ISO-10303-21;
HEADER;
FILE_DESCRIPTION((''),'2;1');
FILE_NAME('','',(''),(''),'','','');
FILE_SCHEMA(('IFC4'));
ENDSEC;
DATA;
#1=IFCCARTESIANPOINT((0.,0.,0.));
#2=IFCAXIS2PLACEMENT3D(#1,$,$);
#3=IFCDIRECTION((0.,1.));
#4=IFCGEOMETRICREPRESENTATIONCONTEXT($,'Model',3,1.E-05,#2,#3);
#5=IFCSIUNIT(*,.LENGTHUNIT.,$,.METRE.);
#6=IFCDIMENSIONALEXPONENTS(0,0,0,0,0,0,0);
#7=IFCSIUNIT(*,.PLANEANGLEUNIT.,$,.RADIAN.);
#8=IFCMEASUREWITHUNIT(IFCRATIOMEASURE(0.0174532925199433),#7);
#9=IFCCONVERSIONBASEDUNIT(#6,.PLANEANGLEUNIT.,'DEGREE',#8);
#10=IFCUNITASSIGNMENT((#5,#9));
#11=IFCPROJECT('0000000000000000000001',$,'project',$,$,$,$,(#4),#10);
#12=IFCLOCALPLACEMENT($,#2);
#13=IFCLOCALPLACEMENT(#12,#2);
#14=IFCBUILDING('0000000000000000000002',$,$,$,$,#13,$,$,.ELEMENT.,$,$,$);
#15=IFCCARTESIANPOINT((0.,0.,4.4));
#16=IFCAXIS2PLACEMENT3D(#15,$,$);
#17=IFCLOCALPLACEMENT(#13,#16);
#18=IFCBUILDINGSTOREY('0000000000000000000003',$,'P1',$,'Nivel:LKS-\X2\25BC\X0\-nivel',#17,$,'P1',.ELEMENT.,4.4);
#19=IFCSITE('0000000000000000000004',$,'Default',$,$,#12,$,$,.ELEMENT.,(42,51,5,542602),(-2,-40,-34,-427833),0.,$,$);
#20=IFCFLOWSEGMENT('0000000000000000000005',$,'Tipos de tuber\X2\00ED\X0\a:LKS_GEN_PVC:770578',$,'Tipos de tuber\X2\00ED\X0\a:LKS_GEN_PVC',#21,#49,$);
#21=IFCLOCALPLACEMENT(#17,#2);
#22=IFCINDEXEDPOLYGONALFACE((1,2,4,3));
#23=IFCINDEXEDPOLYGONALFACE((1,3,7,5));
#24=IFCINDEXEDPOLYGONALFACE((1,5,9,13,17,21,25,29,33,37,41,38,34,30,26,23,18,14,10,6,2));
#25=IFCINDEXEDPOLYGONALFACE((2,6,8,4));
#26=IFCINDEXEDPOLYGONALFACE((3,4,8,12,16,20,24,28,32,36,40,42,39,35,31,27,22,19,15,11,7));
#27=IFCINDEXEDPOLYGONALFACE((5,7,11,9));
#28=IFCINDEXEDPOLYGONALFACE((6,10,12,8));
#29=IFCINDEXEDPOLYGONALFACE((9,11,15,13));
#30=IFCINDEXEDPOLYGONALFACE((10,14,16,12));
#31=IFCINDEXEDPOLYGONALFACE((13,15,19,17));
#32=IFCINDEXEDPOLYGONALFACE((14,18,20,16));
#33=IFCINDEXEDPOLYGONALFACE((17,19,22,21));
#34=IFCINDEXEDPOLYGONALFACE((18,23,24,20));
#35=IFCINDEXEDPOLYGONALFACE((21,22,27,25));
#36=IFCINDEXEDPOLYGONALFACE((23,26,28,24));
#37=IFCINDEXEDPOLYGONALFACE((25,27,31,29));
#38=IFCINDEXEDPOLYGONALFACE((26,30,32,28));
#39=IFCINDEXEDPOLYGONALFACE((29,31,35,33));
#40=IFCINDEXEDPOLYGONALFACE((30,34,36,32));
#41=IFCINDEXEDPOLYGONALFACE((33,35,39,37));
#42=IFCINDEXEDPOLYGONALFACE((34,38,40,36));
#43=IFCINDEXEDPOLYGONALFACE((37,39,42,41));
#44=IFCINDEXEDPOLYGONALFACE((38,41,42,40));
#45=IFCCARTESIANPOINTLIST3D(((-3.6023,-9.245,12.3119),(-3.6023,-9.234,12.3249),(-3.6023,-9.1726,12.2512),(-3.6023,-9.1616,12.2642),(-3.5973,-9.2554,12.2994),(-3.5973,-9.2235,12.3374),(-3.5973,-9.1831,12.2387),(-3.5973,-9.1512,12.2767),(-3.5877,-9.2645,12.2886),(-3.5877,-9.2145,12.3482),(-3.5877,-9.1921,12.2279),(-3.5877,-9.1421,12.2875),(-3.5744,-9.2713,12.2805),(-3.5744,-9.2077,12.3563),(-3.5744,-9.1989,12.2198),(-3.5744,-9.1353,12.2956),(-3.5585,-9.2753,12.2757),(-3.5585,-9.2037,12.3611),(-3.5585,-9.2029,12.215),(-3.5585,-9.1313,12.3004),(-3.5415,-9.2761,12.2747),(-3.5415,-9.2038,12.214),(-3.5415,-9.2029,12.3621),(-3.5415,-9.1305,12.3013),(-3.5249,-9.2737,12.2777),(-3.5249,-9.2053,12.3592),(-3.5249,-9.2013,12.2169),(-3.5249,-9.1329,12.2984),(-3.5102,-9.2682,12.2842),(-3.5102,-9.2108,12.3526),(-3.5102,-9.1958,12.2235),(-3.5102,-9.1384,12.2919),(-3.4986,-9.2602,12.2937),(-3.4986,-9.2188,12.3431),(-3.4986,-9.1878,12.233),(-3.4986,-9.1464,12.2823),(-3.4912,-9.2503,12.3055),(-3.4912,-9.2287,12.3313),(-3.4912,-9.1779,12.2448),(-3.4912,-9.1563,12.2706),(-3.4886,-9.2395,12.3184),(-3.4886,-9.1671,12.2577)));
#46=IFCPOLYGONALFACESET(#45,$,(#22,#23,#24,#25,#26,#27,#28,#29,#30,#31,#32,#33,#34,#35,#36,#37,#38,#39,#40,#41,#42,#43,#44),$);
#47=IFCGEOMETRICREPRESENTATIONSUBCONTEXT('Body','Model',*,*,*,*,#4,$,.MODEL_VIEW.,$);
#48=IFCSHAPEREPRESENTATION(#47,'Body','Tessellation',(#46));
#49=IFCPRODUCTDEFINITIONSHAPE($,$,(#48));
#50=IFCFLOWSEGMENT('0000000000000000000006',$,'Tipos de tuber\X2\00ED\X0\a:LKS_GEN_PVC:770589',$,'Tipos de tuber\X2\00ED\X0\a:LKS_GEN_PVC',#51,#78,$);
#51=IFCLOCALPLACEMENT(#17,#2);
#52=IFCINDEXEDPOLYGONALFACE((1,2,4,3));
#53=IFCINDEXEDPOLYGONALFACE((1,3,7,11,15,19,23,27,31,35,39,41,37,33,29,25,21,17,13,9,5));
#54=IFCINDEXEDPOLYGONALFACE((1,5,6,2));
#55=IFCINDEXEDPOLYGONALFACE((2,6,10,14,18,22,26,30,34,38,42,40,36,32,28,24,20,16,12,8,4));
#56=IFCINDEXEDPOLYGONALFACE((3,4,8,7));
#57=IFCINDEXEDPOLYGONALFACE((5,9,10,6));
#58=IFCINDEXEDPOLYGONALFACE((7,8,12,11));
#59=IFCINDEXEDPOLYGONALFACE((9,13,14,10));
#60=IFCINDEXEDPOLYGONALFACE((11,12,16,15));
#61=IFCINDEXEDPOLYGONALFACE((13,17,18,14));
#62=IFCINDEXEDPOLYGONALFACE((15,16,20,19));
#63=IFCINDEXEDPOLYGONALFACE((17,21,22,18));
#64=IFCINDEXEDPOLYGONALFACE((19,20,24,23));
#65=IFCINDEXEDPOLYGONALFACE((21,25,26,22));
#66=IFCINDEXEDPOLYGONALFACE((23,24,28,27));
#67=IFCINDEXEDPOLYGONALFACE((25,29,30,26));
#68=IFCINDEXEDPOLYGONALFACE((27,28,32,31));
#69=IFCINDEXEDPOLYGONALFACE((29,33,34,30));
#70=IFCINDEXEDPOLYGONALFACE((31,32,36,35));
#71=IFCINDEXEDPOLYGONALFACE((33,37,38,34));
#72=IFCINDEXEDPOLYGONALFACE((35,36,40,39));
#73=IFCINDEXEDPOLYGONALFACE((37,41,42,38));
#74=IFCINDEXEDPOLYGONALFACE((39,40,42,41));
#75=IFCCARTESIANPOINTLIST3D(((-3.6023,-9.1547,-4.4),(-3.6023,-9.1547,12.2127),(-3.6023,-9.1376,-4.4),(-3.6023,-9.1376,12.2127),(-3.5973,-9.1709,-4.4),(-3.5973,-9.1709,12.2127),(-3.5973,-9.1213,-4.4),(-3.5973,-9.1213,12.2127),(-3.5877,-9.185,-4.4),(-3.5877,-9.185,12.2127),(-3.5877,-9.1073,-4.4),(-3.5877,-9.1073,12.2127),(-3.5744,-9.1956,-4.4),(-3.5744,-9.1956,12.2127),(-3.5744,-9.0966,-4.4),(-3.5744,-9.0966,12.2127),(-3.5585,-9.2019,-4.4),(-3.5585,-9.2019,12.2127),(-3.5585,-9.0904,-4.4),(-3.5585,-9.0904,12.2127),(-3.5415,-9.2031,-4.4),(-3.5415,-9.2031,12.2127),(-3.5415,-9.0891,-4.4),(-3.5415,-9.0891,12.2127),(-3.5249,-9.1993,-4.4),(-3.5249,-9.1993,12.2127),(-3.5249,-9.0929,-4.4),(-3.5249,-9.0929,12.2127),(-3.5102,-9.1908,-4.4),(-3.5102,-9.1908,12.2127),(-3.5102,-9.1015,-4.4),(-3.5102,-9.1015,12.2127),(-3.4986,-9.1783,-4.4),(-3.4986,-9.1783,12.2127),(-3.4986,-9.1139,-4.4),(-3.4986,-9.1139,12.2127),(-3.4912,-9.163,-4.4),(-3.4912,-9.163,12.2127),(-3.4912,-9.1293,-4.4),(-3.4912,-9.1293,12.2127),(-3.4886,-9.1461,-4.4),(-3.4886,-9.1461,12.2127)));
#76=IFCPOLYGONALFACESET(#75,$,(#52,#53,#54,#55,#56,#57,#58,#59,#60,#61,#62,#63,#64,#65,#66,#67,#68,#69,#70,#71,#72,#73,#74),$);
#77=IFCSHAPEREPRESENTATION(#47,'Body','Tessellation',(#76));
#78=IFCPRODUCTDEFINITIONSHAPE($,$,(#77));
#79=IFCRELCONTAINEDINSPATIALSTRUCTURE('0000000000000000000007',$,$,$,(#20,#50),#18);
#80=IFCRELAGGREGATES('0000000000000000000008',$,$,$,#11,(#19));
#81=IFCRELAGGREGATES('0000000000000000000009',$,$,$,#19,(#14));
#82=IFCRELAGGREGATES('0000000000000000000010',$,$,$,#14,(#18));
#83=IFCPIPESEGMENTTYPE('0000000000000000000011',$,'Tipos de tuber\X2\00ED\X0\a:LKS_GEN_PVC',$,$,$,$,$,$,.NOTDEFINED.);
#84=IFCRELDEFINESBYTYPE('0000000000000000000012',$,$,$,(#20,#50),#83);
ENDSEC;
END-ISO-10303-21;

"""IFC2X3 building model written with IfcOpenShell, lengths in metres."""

from ifc_helpers import new_model, entity, si_unit, converted_unit, direction, frame, origin, origin_2d_with_axis, place, context, subcontext, project, spatial, circle, extrude, type_object, element, save


model = new_model("IFC2X3")

# Units and contexts
model_context = context("Model", 3, precision=1e-05, world=origin(), true_north=direction((0.0, 1.0)))
body_context = subcontext(model_context, "Body", "Model", "MODEL_VIEW")
ifc_project = project(units=[si_unit("LENGTHUNIT", "METRE"), converted_unit("PLANEANGLEUNIT", "DEGREE", entity("IfcRatioMeasure", 0.0174532925199433), si_unit("PLANEANGLEUNIT", "RADIAN"), dimensions=[0, 0, 0, 0, 0, 0, 0])], contexts=[model_context])

# Site, building, storey
site_placement = place(None, origin())
site = spatial("IfcSite", under=ifc_project, at=site_placement, Name="Default", CompositionType="ELEMENT", RefLatitude=(42, 51, 5, 542602), RefLongitude=(-2, -40, -34, -427833), RefElevation=0.0)
building_placement = place(site_placement, origin())
building = spatial("IfcBuilding", under=site, at=building_placement, CompositionType="ELEMENT")
storey_placement = place(building_placement, frame((0.0, 0.0, 4.4)))
storey = spatial("IfcBuildingStorey", under=building, at=storey_placement, Name="P1", ObjectType="Nivel:LKS-▼-nivel", LongName="P1", CompositionType="ELEMENT", Elevation=4.4)

# Flow segments
pipe_segment_type = type_object("IfcPipeSegmentType", Name="Tipos de tubería:LKS_GEN_PVC", PredefinedType="NOTDEFINED")
flow_segment_1_placement = place(storey_placement, origin())
element("IfcFlowSegment", 1, at=flow_segment_1_placement, inside=storey, type_object=pipe_segment_type, Name="Tipos de tubería:LKS_GEN_PVC:770578", ObjectType="Tipos de tubería:LKS_GEN_PVC", context=body_context, shape_type="SweptSolid", body=[
    extrude(circle(Radius=0.0571, at=origin_2d_with_axis()), frame((-3.5458, -9.1671, 12.2577), z_axis=(0.0, -0.766044, 0.642788), x_axis=(1.0, 0.0, 0.0)), (0.0, 0.0, 1.0), 0.0945),
])
flow_segment_2_placement = place(storey_placement, origin())
element("IfcFlowSegment", 2, at=flow_segment_2_placement, inside=storey, type_object=pipe_segment_type, Name="Tipos de tubería:LKS_GEN_PVC:770589", ObjectType="Tipos de tubería:LKS_GEN_PVC", context=body_context, shape_type="SweptSolid", body=[
    extrude(circle(Radius=0.0571, at=origin_2d_with_axis()), frame((-3.5458, -9.1461, -4.4)), (0.0, 0.0, 1.0), 16.6127),
])

save(model, "model.ifc")
